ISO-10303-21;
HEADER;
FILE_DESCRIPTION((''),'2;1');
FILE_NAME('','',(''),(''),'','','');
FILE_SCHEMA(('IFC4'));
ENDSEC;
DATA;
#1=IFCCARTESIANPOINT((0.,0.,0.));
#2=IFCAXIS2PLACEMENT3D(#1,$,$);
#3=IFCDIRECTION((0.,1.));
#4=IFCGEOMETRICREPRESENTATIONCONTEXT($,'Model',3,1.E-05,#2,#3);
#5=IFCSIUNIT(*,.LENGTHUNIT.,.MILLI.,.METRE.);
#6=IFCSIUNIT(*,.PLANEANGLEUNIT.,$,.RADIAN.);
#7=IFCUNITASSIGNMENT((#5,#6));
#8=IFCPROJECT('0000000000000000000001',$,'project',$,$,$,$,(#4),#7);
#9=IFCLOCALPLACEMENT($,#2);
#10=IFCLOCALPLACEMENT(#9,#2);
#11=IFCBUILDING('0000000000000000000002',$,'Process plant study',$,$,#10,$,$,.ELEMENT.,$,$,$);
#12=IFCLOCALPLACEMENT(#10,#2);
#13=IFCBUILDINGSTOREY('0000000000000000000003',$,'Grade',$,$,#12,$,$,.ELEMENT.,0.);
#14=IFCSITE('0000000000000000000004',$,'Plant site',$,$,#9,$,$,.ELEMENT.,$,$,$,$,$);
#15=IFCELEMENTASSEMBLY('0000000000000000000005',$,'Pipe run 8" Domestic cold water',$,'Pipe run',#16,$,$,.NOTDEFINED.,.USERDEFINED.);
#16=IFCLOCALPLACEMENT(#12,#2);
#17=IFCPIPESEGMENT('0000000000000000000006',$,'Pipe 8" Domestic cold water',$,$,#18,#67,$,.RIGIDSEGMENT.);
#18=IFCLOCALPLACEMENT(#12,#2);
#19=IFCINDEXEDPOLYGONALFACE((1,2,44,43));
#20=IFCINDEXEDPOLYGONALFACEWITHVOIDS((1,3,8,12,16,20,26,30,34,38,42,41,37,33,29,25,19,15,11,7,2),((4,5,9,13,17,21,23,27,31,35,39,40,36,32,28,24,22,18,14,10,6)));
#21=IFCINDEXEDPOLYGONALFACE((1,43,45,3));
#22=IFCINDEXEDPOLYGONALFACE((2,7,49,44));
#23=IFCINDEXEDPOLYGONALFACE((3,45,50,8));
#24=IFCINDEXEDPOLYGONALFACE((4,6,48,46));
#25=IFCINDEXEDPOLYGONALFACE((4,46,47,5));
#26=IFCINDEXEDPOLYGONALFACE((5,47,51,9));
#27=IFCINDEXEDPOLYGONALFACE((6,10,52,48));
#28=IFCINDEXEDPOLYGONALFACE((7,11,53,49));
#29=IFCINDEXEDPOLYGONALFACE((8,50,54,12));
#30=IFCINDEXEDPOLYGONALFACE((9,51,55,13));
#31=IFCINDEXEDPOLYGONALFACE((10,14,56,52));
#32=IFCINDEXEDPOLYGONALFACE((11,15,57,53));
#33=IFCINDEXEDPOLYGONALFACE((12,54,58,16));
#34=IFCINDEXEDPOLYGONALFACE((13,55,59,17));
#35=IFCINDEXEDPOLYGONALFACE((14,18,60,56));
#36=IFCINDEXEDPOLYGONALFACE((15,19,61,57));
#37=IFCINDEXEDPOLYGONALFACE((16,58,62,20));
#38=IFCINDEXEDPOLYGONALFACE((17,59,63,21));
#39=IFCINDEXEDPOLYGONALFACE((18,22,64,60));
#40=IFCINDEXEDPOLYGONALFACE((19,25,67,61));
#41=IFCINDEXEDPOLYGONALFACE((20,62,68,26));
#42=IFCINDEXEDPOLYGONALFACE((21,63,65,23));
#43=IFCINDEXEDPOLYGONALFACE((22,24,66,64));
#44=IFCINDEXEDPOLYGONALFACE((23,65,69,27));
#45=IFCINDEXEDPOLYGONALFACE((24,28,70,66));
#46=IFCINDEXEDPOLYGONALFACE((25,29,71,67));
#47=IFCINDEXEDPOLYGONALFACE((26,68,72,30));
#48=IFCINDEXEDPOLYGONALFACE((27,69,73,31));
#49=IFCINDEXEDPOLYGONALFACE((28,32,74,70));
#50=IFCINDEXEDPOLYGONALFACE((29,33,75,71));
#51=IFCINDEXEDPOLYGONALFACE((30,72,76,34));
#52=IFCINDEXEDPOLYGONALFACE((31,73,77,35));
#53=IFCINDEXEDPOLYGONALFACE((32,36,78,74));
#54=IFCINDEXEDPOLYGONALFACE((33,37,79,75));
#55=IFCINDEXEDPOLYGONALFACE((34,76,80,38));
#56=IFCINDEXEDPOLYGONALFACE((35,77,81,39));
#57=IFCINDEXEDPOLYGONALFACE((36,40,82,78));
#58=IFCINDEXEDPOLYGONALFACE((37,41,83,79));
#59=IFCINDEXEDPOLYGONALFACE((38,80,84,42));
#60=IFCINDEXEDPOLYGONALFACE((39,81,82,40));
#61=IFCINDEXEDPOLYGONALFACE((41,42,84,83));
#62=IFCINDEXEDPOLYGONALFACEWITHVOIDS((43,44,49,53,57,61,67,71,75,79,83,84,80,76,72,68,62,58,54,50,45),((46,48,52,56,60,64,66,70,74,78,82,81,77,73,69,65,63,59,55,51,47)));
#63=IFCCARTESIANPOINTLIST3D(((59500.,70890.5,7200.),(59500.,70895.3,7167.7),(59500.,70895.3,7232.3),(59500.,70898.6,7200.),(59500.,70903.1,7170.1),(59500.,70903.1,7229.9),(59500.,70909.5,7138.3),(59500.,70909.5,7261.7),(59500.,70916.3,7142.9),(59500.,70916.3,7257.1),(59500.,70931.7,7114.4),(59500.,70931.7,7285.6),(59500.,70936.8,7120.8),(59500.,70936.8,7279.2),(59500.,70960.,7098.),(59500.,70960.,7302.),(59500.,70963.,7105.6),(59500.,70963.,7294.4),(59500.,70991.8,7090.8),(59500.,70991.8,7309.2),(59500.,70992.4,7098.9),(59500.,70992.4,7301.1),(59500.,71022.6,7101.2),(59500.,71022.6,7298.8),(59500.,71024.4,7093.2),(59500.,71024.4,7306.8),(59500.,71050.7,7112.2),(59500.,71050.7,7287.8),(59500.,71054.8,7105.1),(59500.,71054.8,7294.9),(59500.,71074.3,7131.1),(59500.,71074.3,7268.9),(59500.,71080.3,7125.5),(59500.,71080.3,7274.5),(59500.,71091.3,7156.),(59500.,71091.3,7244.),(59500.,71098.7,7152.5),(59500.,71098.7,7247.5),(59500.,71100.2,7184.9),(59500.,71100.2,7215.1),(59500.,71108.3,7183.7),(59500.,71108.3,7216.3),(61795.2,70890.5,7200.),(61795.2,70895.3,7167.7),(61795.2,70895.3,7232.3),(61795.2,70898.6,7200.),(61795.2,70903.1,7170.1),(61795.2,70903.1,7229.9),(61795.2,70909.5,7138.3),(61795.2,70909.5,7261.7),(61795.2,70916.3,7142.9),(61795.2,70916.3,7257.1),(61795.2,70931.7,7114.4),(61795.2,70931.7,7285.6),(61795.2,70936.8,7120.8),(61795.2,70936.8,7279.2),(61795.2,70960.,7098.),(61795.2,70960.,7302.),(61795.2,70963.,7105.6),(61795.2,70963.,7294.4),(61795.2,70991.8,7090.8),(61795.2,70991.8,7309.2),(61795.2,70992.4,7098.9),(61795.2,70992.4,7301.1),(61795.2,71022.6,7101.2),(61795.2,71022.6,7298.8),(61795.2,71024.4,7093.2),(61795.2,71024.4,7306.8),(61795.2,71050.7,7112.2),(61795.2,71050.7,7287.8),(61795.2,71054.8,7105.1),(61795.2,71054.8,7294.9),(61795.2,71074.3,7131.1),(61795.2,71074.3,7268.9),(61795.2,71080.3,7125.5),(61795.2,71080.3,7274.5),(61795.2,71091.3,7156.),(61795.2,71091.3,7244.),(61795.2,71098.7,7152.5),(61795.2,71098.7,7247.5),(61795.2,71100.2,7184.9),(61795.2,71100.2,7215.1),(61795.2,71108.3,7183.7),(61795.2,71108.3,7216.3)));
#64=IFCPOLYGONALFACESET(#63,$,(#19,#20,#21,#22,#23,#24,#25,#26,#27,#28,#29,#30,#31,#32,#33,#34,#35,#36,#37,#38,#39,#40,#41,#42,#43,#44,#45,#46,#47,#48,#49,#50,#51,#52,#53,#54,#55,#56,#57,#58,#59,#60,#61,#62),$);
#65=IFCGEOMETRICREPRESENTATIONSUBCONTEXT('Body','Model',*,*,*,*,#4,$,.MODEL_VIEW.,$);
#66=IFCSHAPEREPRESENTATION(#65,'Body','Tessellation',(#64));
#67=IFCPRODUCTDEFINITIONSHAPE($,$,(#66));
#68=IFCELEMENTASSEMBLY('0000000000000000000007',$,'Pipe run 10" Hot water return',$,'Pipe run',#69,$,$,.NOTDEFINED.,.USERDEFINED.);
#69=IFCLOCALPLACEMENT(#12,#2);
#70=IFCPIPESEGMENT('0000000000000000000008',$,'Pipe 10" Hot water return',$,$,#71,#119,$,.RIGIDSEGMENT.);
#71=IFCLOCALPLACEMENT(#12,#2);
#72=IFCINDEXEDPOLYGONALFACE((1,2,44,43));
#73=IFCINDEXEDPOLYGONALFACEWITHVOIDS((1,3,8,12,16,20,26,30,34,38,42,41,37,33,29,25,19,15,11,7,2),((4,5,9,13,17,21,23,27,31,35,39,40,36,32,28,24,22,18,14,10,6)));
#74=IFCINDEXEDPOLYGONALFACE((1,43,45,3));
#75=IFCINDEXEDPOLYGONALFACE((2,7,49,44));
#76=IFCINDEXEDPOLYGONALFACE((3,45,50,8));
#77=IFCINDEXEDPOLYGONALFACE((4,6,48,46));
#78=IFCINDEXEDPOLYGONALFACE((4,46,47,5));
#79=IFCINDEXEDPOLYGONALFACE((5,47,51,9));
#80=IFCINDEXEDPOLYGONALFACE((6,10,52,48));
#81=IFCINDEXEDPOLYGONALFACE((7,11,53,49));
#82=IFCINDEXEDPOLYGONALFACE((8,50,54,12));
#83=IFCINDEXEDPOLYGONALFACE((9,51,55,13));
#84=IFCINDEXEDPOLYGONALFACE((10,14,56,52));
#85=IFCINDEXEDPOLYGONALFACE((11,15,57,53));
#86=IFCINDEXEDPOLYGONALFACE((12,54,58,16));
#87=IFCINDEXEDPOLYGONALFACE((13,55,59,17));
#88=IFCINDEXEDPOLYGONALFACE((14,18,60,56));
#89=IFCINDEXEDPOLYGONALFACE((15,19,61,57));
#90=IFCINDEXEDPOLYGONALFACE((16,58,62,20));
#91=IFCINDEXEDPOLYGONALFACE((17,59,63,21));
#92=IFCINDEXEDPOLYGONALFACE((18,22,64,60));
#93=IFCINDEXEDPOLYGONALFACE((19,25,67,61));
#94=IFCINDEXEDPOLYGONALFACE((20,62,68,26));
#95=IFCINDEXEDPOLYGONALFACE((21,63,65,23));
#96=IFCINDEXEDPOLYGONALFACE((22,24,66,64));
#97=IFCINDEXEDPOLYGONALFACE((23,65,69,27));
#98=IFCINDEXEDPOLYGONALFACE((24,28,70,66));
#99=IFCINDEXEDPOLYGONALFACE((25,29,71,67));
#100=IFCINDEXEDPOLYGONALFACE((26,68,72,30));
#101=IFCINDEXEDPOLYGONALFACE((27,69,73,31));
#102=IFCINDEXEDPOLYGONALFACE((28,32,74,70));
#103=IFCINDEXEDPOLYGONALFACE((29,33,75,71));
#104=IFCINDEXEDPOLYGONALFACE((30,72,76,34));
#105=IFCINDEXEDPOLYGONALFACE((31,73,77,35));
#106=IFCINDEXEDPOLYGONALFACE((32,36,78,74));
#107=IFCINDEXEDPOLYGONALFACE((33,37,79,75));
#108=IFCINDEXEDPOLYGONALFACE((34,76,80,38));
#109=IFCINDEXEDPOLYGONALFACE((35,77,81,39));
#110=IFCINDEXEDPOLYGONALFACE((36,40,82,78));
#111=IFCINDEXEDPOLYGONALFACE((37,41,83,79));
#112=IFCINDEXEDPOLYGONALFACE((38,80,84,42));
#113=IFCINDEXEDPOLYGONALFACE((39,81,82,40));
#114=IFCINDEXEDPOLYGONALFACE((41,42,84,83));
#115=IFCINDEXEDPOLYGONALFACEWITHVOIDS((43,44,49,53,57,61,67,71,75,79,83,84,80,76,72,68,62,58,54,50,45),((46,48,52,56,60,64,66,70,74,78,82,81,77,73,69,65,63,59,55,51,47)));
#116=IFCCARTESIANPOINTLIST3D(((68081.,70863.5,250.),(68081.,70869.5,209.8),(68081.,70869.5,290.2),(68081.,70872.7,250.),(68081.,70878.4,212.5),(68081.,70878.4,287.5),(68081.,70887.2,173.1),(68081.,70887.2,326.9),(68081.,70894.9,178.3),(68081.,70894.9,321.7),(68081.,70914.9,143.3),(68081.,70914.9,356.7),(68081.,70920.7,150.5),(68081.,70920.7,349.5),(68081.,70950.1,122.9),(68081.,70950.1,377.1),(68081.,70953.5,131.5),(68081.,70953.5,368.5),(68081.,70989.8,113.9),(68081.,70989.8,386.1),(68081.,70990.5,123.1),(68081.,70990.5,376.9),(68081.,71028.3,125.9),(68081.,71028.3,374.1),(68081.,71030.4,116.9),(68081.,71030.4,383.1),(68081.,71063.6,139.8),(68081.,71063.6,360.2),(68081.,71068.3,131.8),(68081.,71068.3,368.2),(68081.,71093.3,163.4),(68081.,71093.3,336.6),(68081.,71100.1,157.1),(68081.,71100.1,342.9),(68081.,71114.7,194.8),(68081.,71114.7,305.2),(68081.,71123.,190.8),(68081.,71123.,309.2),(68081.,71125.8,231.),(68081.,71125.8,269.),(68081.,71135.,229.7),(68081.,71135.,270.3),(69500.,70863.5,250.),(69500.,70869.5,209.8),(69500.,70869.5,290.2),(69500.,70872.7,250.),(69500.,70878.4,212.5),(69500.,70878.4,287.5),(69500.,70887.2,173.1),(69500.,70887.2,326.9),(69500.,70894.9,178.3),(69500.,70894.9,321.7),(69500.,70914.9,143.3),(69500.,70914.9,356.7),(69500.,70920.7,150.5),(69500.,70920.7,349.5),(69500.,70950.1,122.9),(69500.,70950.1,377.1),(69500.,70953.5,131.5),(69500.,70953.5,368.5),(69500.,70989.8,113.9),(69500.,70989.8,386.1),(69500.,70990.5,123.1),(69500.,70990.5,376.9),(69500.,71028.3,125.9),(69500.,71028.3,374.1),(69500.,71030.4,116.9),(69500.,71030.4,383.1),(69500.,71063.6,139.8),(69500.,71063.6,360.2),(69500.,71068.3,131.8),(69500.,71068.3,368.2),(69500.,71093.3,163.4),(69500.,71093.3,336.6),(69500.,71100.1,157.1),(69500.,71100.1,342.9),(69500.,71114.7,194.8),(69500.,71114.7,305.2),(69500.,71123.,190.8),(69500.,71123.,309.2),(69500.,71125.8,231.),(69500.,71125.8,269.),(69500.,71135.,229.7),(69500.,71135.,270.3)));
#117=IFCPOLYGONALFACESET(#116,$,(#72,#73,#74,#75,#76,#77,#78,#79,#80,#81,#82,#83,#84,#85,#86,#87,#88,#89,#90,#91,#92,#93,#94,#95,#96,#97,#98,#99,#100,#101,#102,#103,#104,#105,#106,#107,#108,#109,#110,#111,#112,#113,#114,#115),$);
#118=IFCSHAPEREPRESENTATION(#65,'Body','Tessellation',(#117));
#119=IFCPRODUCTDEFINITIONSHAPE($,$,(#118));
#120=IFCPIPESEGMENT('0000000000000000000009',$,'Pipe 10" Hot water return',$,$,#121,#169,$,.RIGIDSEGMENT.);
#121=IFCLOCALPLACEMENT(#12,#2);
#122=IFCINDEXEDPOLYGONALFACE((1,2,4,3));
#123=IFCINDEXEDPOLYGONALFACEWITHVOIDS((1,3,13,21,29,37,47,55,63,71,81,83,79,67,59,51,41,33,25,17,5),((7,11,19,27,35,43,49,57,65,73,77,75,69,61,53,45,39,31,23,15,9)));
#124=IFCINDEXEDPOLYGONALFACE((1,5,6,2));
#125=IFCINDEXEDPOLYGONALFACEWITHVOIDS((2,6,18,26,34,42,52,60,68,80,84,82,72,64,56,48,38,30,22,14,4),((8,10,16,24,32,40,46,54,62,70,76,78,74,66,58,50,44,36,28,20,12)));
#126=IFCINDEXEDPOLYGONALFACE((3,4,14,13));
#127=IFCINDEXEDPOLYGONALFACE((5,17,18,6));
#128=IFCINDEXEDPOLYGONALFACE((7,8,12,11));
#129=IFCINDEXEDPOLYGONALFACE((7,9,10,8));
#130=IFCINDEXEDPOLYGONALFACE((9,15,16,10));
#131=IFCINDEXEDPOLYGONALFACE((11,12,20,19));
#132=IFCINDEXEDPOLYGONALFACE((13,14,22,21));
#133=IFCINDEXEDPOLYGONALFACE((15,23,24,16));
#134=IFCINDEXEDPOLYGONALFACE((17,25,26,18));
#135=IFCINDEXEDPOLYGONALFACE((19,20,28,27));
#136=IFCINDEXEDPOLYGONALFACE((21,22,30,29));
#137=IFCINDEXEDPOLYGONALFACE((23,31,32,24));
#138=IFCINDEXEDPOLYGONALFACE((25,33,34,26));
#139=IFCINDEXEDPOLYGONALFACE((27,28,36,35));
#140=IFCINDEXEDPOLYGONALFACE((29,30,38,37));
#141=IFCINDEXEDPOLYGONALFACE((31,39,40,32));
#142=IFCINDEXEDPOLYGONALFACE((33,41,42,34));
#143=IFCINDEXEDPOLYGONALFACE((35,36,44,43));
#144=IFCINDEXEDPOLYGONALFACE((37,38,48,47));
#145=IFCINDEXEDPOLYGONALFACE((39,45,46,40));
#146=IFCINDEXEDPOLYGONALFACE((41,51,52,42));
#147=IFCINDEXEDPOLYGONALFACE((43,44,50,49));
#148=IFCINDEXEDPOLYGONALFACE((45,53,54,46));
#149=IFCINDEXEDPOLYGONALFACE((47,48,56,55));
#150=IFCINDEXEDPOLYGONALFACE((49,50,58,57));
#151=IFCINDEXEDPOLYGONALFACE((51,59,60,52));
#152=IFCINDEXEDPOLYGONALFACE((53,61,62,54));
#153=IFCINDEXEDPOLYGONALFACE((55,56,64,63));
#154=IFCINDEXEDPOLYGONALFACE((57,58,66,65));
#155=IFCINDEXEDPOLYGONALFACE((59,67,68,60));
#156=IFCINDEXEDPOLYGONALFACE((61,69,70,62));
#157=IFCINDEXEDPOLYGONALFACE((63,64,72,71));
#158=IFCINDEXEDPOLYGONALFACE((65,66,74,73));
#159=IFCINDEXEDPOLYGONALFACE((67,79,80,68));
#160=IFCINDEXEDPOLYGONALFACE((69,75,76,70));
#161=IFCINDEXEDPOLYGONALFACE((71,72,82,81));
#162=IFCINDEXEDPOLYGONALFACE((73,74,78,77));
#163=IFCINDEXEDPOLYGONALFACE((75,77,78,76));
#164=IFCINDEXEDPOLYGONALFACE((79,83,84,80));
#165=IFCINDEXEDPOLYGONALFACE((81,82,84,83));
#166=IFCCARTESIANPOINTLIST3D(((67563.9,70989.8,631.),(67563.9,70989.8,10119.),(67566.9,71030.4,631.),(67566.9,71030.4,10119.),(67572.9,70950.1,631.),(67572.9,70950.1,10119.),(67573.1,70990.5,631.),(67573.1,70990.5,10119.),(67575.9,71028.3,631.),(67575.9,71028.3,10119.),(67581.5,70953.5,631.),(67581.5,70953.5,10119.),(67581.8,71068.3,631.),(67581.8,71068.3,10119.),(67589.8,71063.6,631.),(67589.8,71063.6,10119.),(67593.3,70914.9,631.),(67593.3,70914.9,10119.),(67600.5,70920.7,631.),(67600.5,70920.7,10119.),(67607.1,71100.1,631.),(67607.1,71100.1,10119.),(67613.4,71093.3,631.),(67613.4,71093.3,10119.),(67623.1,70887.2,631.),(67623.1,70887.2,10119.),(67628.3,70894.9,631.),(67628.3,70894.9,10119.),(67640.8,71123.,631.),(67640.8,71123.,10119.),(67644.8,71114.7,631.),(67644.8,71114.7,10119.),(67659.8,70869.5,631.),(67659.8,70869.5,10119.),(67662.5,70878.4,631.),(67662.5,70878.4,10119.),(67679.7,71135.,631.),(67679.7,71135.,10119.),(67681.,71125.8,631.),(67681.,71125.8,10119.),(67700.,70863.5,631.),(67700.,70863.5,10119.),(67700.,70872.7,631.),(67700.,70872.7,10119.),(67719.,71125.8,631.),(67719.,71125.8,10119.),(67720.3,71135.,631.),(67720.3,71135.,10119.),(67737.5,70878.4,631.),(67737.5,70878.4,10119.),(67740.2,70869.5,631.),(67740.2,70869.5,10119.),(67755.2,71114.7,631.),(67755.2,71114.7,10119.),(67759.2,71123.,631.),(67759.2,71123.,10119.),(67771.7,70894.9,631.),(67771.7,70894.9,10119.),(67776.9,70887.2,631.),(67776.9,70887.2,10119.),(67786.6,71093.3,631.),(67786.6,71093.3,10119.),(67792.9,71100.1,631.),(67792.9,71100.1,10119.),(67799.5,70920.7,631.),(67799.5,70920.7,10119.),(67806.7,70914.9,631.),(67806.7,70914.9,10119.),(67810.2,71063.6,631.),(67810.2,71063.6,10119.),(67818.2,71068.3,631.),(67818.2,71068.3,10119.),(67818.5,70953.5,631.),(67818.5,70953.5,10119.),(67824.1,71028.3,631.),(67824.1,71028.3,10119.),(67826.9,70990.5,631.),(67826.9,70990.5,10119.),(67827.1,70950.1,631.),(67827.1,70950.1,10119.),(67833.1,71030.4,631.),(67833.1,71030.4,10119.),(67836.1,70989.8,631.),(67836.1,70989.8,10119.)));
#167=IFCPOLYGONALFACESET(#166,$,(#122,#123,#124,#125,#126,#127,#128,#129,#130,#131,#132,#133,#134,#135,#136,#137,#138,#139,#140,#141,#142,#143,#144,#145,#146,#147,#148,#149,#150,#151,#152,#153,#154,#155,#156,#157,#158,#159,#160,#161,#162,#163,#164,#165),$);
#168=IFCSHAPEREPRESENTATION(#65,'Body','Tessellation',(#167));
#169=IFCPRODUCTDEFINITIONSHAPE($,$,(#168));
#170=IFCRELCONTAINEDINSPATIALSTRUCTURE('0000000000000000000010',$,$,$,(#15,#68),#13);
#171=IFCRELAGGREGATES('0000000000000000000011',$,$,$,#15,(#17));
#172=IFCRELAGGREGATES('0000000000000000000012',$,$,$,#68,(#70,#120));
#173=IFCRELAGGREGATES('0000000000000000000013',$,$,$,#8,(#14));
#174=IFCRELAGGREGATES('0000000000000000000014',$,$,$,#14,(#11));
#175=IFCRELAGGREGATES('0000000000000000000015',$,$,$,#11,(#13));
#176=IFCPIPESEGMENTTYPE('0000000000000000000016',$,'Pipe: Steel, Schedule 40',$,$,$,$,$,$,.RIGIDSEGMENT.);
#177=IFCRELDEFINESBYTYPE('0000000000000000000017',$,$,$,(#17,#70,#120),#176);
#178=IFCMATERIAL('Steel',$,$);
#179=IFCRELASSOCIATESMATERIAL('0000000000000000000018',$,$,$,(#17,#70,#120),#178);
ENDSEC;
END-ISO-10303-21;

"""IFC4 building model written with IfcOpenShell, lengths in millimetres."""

from ifc_helpers import new_model, si_unit, direction, frame, origin, origin_with_axes, origin_2d, place, context, subcontext, project, spatial, hollow_circle, extrude, material, type_object, element, aggregate, save


model = new_model("IFC4")

# Units and contexts
model_context = context("Model", 3, precision=1e-05, world=origin(), true_north=direction((0.0, 1.0)))
body_context = subcontext(model_context, "Body", "Model", "MODEL_VIEW")
ifc_project = project(units=[si_unit("LENGTHUNIT", "METRE", prefix="MILLI"), si_unit("PLANEANGLEUNIT", "RADIAN")], contexts=[model_context])

# Site, building, storey
site_placement = place(None, origin())
site = spatial("IfcSite", under=ifc_project, at=site_placement, Name="Plant site", CompositionType="ELEMENT")
building_placement = place(site_placement, origin())
building = spatial("IfcBuilding", under=site, at=building_placement, Name="Process plant study", CompositionType="ELEMENT")
storey_placement = place(building_placement, origin())
storey = spatial("IfcBuildingStorey", under=building, at=storey_placement, Name="Grade", CompositionType="ELEMENT", Elevation=0.0)

# Shared definitions
ifc_material = material(Name="Steel")
pipe_segment_type = type_object("IfcPipeSegmentType", Name="Pipe: Steel, Schedule 40", PredefinedType="RIGIDSEGMENT")

# Element assemblies, pipe segments
assembly_1_placement = place(storey_placement, origin_with_axes())
assembly_1 = element("IfcElementAssembly", 1, at=assembly_1_placement, inside=storey, Name="Pipe run 8\" Domestic cold water", ObjectType="Pipe run", AssemblyPlace="NOTDEFINED", PredefinedType="USERDEFINED")
pipe_segment_1_placement = place(storey_placement, origin_with_axes())
pipe_segment_1 = element("IfcPipeSegment", 2, at=pipe_segment_1_placement, type_object=pipe_segment_type, material=ifc_material, Name="Pipe 8\" Domestic cold water", PredefinedType="RIGIDSEGMENT", context=body_context, shape_type="SweptSolid", body=[
    extrude(hollow_circle(Radius=109.5, WallThickness=8.2, at=origin_2d()), frame((61795.2, 71000.0, 7200.0), z_axis=(-1.0, 0.0, 0.0), x_axis=(0.0, -1.0, 0.0)), (0.0, 0.0, 1.0), 2295.2),
])
assembly_2_placement = place(storey_placement, origin_with_axes())
assembly_2 = element("IfcElementAssembly", 3, at=assembly_2_placement, inside=storey, Name="Pipe run 10\" Hot water return", ObjectType="Pipe run", AssemblyPlace="NOTDEFINED", PredefinedType="USERDEFINED")
pipe_segment_2_placement = place(storey_placement, origin_with_axes())
pipe_segment_2 = element("IfcPipeSegment", 4, at=pipe_segment_2_placement, type_object=pipe_segment_type, material=ifc_material, Name="Pipe 10\" Hot water return", PredefinedType="RIGIDSEGMENT", context=body_context, shape_type="SweptSolid", body=[
    extrude(hollow_circle(Radius=136.5, WallThickness=9.3, at=origin_2d()), frame((69500.0, 71000.0, 250.0), z_axis=(-1.0, 0.0, 0.0), x_axis=(0.0, -1.0, 0.0)), (0.0, 0.0, 1.0), 1419.0),
])
pipe_segment_3_placement = place(storey_placement, origin_with_axes())
pipe_segment_3 = element("IfcPipeSegment", 5, at=pipe_segment_3_placement, type_object=pipe_segment_type, material=ifc_material, Name="Pipe 10\" Hot water return", PredefinedType="RIGIDSEGMENT", context=body_context, shape_type="SweptSolid", body=[
    extrude(hollow_circle(Radius=136.5, WallThickness=9.3, at=origin_2d()), frame((67700.0, 71000.0, 631.0), z_axis=(0.0, 0.0, 1.0), x_axis=(0.0, -1.0, 0.0)), (0.0, 0.0, 1.0), 9488.0),
])

aggregate(assembly_1, [pipe_segment_1])
aggregate(assembly_2, [pipe_segment_2, pipe_segment_3])

save(model, "model.ifc")
